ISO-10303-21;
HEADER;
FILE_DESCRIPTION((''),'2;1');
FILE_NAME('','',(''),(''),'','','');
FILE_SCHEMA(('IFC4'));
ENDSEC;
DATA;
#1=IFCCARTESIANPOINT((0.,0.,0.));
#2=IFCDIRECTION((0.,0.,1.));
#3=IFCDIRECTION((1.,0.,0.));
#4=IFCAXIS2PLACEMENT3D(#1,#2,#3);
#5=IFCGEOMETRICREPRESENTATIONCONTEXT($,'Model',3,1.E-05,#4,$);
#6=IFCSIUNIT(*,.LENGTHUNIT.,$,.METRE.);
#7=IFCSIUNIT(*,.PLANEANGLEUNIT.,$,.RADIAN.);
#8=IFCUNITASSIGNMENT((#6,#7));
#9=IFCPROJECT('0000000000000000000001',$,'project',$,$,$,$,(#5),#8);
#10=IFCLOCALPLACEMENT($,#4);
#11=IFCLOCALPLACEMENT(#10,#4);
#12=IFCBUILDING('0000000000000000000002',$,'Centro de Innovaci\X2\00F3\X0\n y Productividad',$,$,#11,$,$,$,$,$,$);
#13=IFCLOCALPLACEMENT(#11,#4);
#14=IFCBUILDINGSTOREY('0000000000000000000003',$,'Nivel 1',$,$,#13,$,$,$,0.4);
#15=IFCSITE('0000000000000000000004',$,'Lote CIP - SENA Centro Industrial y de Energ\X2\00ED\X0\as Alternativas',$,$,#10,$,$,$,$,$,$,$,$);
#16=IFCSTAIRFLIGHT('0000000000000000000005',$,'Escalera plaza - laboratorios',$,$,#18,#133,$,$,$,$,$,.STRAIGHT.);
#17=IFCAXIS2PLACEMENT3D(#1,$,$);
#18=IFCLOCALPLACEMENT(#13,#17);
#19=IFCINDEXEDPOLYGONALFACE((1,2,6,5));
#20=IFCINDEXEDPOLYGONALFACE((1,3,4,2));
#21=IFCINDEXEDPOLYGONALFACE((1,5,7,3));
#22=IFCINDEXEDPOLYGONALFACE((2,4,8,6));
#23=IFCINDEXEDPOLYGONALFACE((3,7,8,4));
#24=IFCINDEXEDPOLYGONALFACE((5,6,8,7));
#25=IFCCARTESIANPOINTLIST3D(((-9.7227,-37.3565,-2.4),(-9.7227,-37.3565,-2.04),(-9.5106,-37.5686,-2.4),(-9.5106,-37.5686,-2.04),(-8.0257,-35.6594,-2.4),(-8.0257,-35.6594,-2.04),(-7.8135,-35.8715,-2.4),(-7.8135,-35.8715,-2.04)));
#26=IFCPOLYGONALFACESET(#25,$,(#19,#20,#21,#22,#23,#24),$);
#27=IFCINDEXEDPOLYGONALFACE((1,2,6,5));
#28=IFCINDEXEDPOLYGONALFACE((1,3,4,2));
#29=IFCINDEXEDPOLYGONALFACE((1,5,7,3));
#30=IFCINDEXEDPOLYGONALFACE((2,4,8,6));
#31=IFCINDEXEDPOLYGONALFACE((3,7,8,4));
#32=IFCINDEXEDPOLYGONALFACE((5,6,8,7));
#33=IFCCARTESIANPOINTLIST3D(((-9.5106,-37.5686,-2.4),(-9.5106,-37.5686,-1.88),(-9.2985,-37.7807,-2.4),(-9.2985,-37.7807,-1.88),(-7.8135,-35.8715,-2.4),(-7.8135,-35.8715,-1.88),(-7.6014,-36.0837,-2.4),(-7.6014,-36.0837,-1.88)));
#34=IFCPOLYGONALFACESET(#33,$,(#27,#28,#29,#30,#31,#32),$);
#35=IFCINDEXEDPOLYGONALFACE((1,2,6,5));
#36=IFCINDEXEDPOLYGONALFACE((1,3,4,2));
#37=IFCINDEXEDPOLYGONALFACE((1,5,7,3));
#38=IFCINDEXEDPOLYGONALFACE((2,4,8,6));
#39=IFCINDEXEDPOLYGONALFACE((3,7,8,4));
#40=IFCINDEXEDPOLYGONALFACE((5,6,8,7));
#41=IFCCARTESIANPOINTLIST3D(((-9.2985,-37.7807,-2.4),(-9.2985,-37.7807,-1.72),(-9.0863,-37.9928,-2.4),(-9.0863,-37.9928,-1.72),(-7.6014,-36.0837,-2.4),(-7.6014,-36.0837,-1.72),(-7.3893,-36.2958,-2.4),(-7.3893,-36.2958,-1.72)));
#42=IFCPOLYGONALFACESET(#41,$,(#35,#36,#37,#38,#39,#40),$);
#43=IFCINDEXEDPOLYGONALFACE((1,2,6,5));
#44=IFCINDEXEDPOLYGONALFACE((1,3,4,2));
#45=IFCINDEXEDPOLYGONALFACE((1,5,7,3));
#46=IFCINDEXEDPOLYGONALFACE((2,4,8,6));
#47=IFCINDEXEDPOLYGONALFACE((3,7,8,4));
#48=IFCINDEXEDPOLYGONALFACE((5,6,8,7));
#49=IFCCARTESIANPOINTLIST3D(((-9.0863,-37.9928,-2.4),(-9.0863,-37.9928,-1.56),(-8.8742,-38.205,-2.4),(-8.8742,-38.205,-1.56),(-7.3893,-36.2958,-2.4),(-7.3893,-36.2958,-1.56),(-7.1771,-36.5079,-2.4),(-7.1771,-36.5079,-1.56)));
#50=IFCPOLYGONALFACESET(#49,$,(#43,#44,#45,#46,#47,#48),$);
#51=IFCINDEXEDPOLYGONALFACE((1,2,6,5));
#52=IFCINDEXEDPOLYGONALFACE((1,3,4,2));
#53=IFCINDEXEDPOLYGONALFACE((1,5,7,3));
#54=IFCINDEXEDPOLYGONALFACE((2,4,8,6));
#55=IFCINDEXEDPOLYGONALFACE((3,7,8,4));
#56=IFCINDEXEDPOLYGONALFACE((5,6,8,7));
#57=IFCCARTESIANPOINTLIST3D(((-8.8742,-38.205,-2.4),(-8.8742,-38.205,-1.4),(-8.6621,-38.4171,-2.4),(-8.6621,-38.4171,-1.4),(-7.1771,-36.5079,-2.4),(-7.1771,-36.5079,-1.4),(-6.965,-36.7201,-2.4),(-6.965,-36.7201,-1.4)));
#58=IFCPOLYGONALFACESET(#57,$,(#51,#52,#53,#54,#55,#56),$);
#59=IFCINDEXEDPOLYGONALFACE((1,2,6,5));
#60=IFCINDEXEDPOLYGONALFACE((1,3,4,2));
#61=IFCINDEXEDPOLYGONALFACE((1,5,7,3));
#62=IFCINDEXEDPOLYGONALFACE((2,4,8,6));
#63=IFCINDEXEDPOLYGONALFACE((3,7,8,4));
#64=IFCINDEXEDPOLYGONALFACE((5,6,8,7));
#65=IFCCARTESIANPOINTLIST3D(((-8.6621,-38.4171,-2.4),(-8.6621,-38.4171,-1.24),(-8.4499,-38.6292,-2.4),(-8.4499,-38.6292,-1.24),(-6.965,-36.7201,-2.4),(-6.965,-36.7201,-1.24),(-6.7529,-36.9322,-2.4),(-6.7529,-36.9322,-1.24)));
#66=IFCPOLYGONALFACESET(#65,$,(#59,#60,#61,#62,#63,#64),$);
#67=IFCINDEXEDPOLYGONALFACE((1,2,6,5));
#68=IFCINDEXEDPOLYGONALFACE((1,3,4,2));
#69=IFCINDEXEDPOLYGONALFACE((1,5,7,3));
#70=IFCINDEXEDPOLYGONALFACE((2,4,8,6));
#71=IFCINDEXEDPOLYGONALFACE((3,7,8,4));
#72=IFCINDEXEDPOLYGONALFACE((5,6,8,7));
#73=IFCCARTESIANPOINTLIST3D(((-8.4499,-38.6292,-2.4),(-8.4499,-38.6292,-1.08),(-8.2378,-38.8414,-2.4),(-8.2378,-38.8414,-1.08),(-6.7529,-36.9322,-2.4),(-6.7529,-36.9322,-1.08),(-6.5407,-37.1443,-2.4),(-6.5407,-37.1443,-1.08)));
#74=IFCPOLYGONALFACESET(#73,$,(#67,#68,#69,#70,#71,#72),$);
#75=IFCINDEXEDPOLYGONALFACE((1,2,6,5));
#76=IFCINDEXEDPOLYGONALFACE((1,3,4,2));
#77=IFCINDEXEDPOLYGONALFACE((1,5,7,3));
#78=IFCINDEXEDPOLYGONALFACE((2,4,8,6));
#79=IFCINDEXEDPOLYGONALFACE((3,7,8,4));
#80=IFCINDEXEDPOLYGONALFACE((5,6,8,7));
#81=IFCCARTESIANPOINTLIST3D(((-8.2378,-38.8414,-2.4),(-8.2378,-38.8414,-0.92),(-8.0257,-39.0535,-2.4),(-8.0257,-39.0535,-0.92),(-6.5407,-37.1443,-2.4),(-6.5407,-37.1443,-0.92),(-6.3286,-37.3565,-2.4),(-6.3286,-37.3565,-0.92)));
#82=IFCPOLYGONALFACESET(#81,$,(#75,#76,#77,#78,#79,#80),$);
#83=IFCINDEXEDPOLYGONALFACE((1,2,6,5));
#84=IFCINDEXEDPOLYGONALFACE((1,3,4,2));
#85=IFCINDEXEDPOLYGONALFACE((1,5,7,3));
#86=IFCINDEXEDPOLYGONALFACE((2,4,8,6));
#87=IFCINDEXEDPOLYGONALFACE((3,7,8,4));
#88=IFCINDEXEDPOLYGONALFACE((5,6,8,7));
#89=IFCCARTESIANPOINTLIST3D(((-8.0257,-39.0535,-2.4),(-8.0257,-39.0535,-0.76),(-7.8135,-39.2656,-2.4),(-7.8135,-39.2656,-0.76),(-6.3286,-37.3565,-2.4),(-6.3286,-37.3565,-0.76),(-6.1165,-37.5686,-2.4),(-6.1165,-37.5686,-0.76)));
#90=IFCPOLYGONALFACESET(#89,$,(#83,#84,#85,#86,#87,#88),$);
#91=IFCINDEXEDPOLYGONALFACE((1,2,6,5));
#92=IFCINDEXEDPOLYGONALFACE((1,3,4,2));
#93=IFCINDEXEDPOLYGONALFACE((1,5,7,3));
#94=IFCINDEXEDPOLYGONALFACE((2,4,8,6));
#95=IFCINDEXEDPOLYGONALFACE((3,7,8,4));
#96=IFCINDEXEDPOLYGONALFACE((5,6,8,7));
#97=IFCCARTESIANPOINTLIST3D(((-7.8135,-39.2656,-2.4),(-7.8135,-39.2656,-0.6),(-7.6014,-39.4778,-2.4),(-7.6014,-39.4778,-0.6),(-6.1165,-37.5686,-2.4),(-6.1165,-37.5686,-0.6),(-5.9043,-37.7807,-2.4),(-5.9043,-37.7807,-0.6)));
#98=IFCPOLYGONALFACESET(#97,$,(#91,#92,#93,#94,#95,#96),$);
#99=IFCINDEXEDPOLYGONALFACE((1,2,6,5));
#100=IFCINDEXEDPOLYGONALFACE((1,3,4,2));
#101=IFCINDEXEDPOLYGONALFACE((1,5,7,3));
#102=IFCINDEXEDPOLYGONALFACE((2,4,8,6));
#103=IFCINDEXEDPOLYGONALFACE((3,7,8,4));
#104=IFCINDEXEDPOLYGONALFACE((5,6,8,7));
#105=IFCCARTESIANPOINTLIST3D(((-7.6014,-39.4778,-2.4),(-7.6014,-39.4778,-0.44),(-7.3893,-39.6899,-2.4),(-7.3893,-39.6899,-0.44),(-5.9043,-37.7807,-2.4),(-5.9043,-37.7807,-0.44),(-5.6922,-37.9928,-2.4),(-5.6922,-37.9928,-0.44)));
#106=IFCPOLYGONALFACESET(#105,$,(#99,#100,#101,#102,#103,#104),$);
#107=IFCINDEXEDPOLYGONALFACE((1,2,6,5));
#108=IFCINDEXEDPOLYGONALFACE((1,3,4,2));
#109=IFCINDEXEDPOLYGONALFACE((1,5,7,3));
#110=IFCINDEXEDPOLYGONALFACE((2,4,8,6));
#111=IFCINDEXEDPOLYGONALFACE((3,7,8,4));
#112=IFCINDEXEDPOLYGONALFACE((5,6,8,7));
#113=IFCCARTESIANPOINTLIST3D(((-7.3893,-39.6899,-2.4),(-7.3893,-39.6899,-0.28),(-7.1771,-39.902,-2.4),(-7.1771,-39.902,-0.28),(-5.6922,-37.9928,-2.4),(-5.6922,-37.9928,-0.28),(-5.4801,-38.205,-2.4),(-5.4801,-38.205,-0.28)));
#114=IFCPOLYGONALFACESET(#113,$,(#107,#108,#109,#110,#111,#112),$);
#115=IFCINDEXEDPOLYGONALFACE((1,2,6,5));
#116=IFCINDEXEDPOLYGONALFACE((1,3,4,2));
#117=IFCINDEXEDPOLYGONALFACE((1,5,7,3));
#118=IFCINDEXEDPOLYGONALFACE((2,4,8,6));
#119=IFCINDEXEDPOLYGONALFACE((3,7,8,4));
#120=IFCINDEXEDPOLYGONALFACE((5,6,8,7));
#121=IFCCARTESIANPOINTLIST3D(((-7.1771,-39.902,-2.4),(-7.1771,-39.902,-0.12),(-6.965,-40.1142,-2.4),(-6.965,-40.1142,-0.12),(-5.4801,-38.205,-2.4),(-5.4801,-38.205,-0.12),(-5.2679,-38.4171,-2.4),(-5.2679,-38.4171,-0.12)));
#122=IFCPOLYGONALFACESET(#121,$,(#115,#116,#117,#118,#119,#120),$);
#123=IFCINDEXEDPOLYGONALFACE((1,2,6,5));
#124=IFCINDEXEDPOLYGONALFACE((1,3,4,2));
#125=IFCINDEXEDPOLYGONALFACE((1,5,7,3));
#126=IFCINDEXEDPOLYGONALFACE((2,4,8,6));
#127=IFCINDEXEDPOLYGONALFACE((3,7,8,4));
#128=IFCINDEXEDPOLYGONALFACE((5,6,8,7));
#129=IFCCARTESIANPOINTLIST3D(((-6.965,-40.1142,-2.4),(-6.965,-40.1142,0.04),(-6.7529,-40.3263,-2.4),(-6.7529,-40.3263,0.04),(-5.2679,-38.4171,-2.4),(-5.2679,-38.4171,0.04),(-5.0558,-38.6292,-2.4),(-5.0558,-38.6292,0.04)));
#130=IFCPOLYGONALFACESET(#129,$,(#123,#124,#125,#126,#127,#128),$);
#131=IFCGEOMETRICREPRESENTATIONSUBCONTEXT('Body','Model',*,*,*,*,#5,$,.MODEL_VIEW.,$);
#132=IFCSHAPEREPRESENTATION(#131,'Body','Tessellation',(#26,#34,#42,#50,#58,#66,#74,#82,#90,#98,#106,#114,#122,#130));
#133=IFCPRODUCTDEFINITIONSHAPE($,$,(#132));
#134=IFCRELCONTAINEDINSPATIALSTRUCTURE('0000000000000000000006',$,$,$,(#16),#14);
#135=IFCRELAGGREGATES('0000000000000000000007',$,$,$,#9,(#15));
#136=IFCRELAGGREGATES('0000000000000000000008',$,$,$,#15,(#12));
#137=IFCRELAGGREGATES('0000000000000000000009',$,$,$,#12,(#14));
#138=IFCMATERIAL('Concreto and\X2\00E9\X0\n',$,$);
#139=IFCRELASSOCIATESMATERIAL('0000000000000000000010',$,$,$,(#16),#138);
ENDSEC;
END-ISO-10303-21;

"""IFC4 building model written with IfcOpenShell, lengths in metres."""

from ifc_helpers import new_model, si_unit, frame, origin_with_axes, place, context, subcontext, project, spatial, polyline, outline, extrude, material, element, save


model = new_model("IFC4")

# Units and contexts
model_context = context("Model", 3, precision=1e-05, world=origin_with_axes())
body_context = subcontext(model_context, "Body", "Model", "MODEL_VIEW")
ifc_project = project(units=[si_unit("LENGTHUNIT", "METRE"), si_unit("PLANEANGLEUNIT", "RADIAN")], contexts=[model_context])

# Site, building, storey
site_placement = place(None, origin_with_axes())
site = spatial("IfcSite", under=ifc_project, at=site_placement, Name="Lote CIP - SENA Centro Industrial y de Energías Alternativas")
building_placement = place(site_placement, origin_with_axes())
building = spatial("IfcBuilding", under=site, at=building_placement, Name="Centro de Innovación y Productividad")
storey_placement = place(building_placement, origin_with_axes())
storey = spatial("IfcBuildingStorey", under=building, at=storey_placement, Name="Nivel 1", Elevation=0.4)

# Shared definitions
ifc_material_1 = material(Name="Concreto andén")

# Stair flight
stair_flight_1_placement = place(storey_placement, origin_with_axes())
element("IfcStairFlight", 1, at=stair_flight_1_placement, inside=storey, material=ifc_material_1, Name="Escalera plaza - laboratorios", PredefinedType="STRAIGHT", context=body_context, shape_type="SweptSolid", body=[
    extrude(outline(polyline([(-9.7227, -37.3565), (-8.0257, -35.6594), (-7.8135, -35.8715), (-9.5106, -37.5686), (-9.7227, -37.3565)])), frame((0.0, 0.0, -2.4)), (0.0, 0.0, 1.0), 0.36),
    extrude(outline(polyline([(-9.5106, -37.5686), (-7.8135, -35.8715), (-7.6014, -36.0837), (-9.2985, -37.7807), (-9.5106, -37.5686)])), frame((0.0, 0.0, -2.4)), (0.0, 0.0, 1.0), 0.52),
    extrude(outline(polyline([(-9.2985, -37.7807), (-7.6014, -36.0837), (-7.3893, -36.2958), (-9.0863, -37.9928), (-9.2985, -37.7807)])), frame((0.0, 0.0, -2.4)), (0.0, 0.0, 1.0), 0.68),
    extrude(outline(polyline([(-9.0863, -37.9928), (-7.3893, -36.2958), (-7.1771, -36.5079), (-8.8742, -38.205), (-9.0863, -37.9928)])), frame((0.0, 0.0, -2.4)), (0.0, 0.0, 1.0), 0.84),
    extrude(outline(polyline([(-8.8742, -38.205), (-7.1771, -36.5079), (-6.965, -36.7201), (-8.6621, -38.4171), (-8.8742, -38.205)])), frame((0.0, 0.0, -2.4)), (0.0, 0.0, 1.0), 1.0),
    extrude(outline(polyline([(-8.6621, -38.4171), (-6.965, -36.7201), (-6.7529, -36.9322), (-8.4499, -38.6292), (-8.6621, -38.4171)])), frame((0.0, 0.0, -2.4)), (0.0, 0.0, 1.0), 1.16),
    extrude(outline(polyline([(-8.4499, -38.6292), (-6.7529, -36.9322), (-6.5407, -37.1443), (-8.2378, -38.8414), (-8.4499, -38.6292)])), frame((0.0, 0.0, -2.4)), (0.0, 0.0, 1.0), 1.32),
    extrude(outline(polyline([(-8.2378, -38.8414), (-6.5407, -37.1443), (-6.3286, -37.3565), (-8.0257, -39.0535), (-8.2378, -38.8414)])), frame((0.0, 0.0, -2.4)), (0.0, 0.0, 1.0), 1.48),
    extrude(outline(polyline([(-8.0257, -39.0535), (-6.3286, -37.3565), (-6.1165, -37.5686), (-7.8135, -39.2656), (-8.0257, -39.0535)])), frame((0.0, 0.0, -2.4)), (0.0, 0.0, 1.0), 1.64),
    extrude(outline(polyline([(-7.8135, -39.2656), (-6.1165, -37.5686), (-5.9043, -37.7807), (-7.6014, -39.4778), (-7.8135, -39.2656)])), frame((0.0, 0.0, -2.4)), (0.0, 0.0, 1.0), 1.8),
    extrude(outline(polyline([(-7.6014, -39.4778), (-5.9043, -37.7807), (-5.6922, -37.9928), (-7.3893, -39.6899), (-7.6014, -39.4778)])), frame((0.0, 0.0, -2.4)), (0.0, 0.0, 1.0), 1.96),
    extrude(outline(polyline([(-7.3893, -39.6899), (-5.6922, -37.9928), (-5.4801, -38.205), (-7.1771, -39.902), (-7.3893, -39.6899)])), frame((0.0, 0.0, -2.4)), (0.0, 0.0, 1.0), 2.12),
    extrude(outline(polyline([(-7.1771, -39.902), (-5.4801, -38.205), (-5.2679, -38.4171), (-6.965, -40.1142), (-7.1771, -39.902)])), frame((0.0, 0.0, -2.4)), (0.0, 0.0, 1.0), 2.28),
    extrude(outline(polyline([(-6.965, -40.1142), (-5.2679, -38.4171), (-5.0558, -38.6292), (-6.7529, -40.3263), (-6.965, -40.1142)])), frame((0.0, 0.0, -2.4)), (0.0, 0.0, 1.0), 2.44),
])

save(model, "model.ifc")
